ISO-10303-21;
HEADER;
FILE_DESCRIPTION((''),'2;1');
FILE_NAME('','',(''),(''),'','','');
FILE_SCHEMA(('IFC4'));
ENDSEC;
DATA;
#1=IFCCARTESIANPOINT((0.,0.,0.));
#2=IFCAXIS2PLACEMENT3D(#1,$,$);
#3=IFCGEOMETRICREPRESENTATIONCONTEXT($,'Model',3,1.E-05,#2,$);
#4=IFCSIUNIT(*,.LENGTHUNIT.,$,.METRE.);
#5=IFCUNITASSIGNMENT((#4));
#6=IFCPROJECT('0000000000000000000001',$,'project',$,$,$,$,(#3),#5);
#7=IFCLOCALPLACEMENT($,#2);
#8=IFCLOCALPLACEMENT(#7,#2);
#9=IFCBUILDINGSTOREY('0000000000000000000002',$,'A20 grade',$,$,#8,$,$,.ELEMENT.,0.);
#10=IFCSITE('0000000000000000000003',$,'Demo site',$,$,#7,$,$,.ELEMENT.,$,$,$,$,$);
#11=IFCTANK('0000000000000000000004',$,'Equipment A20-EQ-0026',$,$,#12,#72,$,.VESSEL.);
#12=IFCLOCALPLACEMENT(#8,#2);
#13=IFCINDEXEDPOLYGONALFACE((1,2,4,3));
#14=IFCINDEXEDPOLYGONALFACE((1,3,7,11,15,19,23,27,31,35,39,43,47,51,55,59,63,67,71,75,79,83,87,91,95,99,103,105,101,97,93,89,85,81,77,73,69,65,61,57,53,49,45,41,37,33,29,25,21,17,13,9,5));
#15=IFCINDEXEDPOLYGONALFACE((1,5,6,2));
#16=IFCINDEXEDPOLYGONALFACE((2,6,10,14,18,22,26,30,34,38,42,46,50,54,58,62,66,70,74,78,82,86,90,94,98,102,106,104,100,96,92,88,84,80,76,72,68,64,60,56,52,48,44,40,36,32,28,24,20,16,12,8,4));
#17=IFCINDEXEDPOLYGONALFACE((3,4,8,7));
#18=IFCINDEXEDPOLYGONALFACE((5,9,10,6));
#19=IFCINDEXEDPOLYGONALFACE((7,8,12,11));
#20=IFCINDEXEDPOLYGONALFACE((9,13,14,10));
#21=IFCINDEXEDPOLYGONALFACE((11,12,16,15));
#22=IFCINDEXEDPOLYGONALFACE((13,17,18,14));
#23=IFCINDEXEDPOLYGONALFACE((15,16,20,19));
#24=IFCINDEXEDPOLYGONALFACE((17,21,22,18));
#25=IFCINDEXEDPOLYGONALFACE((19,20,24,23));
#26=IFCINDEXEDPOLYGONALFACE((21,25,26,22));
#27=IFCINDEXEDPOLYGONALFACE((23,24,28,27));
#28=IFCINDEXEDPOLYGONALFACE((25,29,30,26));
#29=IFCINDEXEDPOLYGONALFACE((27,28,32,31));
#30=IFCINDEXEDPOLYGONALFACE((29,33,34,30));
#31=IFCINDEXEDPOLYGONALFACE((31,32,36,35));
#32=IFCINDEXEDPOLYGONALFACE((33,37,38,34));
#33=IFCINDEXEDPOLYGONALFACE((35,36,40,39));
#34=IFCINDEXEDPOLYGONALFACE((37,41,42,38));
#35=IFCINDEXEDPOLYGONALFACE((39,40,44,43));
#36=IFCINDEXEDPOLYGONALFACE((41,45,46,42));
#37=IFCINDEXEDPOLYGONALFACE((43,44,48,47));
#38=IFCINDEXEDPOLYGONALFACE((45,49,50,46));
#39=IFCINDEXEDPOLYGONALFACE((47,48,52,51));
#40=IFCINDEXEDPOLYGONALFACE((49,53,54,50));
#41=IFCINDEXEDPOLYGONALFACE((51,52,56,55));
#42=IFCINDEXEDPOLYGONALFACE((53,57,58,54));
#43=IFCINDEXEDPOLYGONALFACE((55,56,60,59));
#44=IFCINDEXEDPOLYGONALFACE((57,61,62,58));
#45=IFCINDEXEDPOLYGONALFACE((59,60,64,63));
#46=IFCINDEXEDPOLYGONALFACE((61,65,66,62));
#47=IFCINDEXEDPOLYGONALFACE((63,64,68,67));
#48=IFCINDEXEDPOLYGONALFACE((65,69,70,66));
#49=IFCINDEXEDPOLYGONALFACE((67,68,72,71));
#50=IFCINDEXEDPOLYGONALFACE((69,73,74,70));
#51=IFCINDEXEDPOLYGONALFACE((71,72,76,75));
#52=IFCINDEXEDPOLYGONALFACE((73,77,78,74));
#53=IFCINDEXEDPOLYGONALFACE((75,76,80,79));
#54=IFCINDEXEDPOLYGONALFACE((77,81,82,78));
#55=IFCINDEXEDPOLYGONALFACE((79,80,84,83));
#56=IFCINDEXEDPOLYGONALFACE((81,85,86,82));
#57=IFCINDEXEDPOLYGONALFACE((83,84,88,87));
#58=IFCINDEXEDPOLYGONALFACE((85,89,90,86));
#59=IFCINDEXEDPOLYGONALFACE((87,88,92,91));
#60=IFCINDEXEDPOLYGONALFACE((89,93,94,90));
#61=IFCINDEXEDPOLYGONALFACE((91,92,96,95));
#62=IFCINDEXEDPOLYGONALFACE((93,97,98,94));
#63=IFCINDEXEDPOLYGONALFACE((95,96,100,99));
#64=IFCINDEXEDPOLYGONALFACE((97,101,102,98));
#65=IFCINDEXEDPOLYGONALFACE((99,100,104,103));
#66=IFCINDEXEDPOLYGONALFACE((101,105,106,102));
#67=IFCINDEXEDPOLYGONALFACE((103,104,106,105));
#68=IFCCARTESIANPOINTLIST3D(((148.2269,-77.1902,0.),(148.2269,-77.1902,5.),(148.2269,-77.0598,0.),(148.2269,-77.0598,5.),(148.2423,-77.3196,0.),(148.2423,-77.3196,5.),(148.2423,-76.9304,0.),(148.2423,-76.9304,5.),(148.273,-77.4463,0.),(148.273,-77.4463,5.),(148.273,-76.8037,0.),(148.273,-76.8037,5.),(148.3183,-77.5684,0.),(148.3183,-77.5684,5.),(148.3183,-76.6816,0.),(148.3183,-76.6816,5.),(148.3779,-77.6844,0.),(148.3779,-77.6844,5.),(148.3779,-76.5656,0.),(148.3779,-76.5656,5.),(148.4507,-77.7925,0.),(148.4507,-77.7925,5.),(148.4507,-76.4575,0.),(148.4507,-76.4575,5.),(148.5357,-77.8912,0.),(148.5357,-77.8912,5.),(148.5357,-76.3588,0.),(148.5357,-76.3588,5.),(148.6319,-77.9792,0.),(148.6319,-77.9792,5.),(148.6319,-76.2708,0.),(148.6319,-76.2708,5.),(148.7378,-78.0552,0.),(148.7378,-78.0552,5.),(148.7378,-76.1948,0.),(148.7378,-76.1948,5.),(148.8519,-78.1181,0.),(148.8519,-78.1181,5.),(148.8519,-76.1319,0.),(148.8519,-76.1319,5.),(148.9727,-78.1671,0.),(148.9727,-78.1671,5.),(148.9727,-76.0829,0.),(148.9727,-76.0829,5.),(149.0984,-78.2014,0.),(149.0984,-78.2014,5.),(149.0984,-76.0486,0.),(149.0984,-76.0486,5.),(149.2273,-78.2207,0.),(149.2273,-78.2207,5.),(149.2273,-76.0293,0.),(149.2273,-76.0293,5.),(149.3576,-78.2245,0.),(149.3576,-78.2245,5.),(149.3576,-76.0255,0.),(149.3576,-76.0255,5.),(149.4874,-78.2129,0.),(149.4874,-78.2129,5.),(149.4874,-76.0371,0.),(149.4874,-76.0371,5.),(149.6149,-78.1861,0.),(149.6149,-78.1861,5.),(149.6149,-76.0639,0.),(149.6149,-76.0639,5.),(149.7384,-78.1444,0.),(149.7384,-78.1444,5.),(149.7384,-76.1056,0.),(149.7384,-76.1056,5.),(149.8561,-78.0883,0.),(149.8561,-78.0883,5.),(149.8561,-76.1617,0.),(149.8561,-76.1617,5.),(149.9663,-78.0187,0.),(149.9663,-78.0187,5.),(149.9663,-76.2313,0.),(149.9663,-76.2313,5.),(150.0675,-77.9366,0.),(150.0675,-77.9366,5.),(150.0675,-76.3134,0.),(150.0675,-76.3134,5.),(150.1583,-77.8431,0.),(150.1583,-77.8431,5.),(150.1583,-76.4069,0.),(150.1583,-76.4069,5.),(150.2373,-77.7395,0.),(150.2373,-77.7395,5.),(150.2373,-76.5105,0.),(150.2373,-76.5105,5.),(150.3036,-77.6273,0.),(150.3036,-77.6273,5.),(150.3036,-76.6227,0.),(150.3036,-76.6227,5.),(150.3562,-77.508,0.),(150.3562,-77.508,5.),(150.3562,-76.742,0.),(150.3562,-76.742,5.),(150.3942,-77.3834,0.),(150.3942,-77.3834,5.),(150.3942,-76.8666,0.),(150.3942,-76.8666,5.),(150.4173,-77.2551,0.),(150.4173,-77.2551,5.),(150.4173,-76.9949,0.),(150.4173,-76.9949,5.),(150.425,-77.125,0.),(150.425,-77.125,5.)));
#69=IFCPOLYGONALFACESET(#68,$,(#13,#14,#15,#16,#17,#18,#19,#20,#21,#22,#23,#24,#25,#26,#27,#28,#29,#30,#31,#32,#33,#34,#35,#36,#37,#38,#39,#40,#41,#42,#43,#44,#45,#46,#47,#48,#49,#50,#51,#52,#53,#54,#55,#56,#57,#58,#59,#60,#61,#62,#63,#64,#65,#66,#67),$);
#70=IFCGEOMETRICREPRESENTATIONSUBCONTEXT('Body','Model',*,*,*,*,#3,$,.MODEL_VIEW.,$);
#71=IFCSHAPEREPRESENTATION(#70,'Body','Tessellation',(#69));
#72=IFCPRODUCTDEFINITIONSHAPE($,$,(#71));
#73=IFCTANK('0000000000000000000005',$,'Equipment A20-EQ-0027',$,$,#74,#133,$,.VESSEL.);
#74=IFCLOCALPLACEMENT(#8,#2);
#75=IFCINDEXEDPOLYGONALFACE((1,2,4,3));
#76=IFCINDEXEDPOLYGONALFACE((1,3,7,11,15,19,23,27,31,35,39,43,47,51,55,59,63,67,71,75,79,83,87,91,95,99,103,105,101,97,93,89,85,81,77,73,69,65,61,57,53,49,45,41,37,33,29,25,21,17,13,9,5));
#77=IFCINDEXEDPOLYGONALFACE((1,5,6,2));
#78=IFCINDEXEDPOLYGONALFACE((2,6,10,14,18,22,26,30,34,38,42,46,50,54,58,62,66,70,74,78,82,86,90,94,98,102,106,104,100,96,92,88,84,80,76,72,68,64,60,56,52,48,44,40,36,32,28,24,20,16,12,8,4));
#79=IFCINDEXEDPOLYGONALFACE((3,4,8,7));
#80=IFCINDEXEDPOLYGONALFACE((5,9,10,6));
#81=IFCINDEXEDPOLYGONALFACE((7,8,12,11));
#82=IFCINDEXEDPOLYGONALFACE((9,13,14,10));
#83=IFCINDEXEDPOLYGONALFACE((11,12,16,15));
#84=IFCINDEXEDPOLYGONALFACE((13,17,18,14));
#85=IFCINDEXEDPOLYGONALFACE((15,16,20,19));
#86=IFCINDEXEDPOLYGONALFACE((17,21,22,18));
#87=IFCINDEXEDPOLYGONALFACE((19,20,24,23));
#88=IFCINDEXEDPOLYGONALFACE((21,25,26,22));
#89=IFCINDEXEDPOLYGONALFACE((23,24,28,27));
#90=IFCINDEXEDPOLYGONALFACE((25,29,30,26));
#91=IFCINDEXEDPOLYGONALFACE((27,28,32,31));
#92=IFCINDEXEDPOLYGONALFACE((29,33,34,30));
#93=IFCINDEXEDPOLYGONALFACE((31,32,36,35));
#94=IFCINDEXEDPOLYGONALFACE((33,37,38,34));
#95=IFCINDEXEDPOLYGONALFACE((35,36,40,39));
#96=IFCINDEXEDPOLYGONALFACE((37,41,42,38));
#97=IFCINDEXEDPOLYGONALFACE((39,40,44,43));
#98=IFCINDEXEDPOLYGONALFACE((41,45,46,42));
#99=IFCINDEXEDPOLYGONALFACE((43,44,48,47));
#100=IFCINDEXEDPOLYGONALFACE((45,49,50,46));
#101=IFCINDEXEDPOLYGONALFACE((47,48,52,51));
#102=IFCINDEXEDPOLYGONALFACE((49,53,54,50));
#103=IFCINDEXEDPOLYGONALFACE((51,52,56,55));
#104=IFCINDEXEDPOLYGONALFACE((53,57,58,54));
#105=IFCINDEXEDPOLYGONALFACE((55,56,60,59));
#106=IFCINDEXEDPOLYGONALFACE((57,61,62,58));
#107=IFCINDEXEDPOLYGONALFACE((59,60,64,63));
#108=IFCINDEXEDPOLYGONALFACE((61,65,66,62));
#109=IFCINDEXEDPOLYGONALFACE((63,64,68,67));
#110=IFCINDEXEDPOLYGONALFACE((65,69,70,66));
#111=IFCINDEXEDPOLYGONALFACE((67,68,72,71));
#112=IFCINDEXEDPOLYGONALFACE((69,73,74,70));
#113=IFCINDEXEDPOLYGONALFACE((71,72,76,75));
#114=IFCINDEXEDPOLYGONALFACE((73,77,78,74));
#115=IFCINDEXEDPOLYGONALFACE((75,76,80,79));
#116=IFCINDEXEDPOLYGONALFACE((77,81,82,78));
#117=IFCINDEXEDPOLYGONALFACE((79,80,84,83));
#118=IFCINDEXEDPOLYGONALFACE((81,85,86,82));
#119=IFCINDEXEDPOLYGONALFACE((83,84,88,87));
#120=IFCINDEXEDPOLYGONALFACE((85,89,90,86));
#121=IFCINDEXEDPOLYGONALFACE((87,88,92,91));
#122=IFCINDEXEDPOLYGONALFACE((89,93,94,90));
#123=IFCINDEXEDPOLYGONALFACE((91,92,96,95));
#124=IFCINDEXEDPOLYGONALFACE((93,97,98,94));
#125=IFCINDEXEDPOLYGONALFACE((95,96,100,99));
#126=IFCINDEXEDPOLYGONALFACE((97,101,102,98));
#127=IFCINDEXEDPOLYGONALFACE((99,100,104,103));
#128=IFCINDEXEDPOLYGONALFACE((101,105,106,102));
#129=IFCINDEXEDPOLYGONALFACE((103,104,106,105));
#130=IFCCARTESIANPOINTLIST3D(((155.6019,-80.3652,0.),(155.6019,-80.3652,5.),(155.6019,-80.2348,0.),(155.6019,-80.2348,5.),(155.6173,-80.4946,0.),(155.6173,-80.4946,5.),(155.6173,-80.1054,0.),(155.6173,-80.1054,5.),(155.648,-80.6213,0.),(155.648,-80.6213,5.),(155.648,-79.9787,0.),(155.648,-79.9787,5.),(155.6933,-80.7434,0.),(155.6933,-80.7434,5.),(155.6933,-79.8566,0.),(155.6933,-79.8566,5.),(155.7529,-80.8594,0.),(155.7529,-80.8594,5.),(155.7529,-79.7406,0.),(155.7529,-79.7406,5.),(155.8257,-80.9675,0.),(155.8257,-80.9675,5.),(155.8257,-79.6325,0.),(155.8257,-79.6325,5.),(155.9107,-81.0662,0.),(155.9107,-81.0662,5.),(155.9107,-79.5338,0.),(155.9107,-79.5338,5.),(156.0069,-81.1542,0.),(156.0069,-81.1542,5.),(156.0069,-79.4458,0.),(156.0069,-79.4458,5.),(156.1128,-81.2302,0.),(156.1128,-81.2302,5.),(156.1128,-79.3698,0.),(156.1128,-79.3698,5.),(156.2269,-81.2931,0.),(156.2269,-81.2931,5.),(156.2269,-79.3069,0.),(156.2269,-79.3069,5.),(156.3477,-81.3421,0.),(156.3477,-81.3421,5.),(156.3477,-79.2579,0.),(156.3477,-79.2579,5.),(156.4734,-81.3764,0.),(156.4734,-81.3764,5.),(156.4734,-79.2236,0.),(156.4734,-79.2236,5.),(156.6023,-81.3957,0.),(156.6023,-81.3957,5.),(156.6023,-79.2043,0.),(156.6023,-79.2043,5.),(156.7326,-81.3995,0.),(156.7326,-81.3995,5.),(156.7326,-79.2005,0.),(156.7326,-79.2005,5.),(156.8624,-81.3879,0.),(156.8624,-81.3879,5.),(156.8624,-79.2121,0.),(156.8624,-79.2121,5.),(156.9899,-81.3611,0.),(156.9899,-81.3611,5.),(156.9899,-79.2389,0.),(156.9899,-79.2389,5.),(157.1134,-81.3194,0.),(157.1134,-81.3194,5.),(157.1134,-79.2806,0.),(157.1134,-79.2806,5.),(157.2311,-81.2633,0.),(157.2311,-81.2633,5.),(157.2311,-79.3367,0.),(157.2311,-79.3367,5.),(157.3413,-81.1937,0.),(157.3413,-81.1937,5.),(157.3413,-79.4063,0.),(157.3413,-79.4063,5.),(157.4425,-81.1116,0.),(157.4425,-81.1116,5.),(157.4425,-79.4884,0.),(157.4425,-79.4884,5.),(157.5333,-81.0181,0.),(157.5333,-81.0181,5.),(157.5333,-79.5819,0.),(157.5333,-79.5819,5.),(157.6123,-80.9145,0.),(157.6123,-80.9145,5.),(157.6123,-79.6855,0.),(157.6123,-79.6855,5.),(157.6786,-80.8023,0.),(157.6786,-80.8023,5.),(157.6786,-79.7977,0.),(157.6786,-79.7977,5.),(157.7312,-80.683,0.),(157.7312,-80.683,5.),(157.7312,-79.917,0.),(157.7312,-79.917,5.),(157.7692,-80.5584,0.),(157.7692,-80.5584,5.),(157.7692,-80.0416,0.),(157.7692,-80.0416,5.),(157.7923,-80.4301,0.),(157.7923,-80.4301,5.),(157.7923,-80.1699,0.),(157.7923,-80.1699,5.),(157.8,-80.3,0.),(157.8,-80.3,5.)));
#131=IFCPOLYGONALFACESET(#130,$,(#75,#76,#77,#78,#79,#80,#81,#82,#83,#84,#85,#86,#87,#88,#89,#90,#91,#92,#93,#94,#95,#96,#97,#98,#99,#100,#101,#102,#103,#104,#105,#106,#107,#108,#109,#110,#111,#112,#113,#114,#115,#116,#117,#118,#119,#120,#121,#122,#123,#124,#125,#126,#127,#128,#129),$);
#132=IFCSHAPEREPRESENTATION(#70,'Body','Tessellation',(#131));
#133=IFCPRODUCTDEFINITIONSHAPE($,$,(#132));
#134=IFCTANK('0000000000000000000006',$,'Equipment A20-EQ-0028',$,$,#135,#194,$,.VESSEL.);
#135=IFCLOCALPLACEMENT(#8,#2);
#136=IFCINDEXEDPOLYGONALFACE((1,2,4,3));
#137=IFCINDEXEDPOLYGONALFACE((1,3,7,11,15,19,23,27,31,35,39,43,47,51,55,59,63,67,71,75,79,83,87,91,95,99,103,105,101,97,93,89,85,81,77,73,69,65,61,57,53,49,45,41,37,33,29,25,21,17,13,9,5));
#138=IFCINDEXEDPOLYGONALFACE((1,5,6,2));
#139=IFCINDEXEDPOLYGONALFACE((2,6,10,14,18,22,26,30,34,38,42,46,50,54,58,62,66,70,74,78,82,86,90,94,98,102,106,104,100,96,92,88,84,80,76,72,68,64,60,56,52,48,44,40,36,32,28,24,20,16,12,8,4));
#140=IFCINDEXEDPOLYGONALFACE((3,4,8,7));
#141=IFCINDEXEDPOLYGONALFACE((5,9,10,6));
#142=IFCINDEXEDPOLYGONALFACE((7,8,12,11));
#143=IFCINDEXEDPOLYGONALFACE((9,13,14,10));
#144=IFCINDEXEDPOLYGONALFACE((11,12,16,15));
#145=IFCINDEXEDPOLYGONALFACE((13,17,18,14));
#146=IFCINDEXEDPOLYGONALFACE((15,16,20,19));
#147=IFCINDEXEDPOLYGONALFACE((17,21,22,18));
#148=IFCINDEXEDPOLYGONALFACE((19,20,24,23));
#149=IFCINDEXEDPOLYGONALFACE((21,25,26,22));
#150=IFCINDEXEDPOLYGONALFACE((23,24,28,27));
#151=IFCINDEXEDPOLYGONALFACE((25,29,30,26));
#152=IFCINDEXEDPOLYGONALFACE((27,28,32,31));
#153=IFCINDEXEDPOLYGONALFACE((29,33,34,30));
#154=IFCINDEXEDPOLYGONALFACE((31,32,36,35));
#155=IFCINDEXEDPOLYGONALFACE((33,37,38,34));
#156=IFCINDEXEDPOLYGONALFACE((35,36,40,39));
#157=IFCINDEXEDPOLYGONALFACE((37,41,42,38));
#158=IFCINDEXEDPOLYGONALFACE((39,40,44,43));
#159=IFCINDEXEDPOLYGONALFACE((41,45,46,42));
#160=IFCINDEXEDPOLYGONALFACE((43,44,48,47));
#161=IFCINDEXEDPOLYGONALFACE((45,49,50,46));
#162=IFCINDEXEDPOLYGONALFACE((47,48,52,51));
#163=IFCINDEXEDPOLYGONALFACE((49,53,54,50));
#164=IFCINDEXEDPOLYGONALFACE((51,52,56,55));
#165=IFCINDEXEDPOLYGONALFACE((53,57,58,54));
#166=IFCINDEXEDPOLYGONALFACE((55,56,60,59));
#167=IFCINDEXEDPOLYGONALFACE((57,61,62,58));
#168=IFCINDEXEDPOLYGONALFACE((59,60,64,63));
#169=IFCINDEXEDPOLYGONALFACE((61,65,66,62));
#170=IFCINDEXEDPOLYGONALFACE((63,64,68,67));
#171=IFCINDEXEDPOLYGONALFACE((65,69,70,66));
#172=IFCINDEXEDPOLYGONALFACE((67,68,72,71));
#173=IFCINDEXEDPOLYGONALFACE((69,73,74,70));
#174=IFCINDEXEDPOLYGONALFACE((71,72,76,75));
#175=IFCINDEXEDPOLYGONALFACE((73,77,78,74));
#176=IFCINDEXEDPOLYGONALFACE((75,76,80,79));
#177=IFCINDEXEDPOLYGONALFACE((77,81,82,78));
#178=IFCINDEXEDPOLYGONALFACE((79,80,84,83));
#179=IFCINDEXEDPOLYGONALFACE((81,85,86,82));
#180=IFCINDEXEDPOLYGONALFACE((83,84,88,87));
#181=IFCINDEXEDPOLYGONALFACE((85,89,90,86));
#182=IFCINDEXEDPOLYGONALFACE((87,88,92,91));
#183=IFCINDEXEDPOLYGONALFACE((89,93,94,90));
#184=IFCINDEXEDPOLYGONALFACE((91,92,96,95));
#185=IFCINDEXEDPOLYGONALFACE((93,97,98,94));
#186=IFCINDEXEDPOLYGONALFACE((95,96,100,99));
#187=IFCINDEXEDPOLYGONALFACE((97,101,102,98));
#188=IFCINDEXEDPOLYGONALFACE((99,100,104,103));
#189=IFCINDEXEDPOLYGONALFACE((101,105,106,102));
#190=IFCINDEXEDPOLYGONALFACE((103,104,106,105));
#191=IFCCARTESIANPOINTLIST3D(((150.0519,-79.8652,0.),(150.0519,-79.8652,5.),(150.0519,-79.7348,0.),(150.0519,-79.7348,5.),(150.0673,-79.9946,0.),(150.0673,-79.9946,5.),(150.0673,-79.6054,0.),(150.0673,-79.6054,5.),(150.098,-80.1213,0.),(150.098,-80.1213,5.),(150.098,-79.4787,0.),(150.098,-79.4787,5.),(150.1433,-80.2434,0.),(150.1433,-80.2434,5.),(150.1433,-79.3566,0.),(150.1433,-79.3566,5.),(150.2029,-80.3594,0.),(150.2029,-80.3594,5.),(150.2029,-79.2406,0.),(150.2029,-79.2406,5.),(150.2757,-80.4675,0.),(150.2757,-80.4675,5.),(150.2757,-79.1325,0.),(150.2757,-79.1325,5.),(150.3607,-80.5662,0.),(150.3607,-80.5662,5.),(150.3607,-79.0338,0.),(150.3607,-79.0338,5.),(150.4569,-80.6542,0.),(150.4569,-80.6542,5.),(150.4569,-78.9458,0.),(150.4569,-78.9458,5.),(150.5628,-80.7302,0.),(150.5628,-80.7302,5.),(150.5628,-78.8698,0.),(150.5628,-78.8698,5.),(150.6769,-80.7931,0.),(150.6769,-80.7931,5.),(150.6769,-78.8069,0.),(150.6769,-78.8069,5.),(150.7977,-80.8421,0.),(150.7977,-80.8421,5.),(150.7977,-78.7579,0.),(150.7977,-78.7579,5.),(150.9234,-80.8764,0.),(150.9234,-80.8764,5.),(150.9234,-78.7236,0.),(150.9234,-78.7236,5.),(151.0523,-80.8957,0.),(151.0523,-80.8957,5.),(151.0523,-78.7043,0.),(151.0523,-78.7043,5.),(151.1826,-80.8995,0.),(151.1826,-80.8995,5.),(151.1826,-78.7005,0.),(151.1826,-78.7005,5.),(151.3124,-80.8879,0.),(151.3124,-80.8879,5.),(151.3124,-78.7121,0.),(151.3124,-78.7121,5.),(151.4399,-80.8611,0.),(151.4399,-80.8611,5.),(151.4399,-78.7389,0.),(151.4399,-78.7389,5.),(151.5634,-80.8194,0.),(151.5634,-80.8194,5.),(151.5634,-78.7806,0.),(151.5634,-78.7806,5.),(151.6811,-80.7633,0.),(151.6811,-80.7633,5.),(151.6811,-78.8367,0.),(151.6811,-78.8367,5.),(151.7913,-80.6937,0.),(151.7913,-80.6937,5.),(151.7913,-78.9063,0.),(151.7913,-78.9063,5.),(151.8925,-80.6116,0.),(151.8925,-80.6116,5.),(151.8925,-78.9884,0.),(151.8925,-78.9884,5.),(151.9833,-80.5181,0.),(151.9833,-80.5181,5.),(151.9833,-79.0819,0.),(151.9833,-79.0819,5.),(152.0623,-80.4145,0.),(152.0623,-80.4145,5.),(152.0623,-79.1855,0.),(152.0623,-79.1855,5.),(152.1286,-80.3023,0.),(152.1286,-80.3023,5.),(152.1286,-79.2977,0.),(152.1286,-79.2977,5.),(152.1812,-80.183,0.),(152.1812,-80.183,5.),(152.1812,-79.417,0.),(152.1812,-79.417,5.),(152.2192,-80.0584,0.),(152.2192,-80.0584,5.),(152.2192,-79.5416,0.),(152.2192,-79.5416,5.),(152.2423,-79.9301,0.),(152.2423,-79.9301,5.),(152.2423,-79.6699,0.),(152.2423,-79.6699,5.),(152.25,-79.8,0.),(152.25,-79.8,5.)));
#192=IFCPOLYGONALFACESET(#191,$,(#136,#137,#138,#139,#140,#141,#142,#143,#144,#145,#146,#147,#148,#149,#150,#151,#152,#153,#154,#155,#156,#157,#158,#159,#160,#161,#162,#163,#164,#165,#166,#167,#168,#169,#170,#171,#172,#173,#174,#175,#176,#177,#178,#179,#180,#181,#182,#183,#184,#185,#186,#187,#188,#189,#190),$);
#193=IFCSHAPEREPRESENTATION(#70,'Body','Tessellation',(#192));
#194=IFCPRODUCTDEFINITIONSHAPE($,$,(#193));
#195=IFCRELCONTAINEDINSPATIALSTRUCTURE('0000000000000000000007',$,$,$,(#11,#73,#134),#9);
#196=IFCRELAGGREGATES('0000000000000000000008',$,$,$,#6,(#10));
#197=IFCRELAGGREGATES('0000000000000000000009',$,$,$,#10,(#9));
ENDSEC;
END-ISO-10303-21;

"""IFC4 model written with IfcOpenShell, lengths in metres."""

from ifc_helpers import new_model, si_unit, frame, origin, place, context, subcontext, project, spatial, circle, extrude, element, save


model = new_model("IFC4")

# Units and contexts
model_context = context("Model", 3, precision=1e-05, world=origin())
body_context = subcontext(model_context, "Body", "Model", "MODEL_VIEW")
ifc_project = project(units=[si_unit("LENGTHUNIT", "METRE")], contexts=[model_context])

# Site, storey
site_placement = place(None, origin())
site = spatial("IfcSite", under=ifc_project, at=site_placement, Name="Demo site", CompositionType="ELEMENT")
storey_placement = place(site_placement, origin())
storey = spatial("IfcBuildingStorey", under=site, at=storey_placement, Name="A20 grade", CompositionType="ELEMENT", Elevation=0.0)

# Tanks
for number, where, name in (
    (1, (149.325, -77.125, 0.0), "Equipment A20-EQ-0026"),
    (2, (156.7, -80.3, 0.0), "Equipment A20-EQ-0027"),
    (3, (151.15, -79.8, 0.0), "Equipment A20-EQ-0028"),
):
    element("IfcTank", number, at=place(storey_placement, frame(where)), inside=storey, Name=name, PredefinedType="VESSEL", context=body_context, shape_type="SweptSolid", body=[
        extrude(circle(Radius=1.1), origin(), (0.0, 0.0, 1.0), 5.0),
    ])

save(model, "model.ifc")
